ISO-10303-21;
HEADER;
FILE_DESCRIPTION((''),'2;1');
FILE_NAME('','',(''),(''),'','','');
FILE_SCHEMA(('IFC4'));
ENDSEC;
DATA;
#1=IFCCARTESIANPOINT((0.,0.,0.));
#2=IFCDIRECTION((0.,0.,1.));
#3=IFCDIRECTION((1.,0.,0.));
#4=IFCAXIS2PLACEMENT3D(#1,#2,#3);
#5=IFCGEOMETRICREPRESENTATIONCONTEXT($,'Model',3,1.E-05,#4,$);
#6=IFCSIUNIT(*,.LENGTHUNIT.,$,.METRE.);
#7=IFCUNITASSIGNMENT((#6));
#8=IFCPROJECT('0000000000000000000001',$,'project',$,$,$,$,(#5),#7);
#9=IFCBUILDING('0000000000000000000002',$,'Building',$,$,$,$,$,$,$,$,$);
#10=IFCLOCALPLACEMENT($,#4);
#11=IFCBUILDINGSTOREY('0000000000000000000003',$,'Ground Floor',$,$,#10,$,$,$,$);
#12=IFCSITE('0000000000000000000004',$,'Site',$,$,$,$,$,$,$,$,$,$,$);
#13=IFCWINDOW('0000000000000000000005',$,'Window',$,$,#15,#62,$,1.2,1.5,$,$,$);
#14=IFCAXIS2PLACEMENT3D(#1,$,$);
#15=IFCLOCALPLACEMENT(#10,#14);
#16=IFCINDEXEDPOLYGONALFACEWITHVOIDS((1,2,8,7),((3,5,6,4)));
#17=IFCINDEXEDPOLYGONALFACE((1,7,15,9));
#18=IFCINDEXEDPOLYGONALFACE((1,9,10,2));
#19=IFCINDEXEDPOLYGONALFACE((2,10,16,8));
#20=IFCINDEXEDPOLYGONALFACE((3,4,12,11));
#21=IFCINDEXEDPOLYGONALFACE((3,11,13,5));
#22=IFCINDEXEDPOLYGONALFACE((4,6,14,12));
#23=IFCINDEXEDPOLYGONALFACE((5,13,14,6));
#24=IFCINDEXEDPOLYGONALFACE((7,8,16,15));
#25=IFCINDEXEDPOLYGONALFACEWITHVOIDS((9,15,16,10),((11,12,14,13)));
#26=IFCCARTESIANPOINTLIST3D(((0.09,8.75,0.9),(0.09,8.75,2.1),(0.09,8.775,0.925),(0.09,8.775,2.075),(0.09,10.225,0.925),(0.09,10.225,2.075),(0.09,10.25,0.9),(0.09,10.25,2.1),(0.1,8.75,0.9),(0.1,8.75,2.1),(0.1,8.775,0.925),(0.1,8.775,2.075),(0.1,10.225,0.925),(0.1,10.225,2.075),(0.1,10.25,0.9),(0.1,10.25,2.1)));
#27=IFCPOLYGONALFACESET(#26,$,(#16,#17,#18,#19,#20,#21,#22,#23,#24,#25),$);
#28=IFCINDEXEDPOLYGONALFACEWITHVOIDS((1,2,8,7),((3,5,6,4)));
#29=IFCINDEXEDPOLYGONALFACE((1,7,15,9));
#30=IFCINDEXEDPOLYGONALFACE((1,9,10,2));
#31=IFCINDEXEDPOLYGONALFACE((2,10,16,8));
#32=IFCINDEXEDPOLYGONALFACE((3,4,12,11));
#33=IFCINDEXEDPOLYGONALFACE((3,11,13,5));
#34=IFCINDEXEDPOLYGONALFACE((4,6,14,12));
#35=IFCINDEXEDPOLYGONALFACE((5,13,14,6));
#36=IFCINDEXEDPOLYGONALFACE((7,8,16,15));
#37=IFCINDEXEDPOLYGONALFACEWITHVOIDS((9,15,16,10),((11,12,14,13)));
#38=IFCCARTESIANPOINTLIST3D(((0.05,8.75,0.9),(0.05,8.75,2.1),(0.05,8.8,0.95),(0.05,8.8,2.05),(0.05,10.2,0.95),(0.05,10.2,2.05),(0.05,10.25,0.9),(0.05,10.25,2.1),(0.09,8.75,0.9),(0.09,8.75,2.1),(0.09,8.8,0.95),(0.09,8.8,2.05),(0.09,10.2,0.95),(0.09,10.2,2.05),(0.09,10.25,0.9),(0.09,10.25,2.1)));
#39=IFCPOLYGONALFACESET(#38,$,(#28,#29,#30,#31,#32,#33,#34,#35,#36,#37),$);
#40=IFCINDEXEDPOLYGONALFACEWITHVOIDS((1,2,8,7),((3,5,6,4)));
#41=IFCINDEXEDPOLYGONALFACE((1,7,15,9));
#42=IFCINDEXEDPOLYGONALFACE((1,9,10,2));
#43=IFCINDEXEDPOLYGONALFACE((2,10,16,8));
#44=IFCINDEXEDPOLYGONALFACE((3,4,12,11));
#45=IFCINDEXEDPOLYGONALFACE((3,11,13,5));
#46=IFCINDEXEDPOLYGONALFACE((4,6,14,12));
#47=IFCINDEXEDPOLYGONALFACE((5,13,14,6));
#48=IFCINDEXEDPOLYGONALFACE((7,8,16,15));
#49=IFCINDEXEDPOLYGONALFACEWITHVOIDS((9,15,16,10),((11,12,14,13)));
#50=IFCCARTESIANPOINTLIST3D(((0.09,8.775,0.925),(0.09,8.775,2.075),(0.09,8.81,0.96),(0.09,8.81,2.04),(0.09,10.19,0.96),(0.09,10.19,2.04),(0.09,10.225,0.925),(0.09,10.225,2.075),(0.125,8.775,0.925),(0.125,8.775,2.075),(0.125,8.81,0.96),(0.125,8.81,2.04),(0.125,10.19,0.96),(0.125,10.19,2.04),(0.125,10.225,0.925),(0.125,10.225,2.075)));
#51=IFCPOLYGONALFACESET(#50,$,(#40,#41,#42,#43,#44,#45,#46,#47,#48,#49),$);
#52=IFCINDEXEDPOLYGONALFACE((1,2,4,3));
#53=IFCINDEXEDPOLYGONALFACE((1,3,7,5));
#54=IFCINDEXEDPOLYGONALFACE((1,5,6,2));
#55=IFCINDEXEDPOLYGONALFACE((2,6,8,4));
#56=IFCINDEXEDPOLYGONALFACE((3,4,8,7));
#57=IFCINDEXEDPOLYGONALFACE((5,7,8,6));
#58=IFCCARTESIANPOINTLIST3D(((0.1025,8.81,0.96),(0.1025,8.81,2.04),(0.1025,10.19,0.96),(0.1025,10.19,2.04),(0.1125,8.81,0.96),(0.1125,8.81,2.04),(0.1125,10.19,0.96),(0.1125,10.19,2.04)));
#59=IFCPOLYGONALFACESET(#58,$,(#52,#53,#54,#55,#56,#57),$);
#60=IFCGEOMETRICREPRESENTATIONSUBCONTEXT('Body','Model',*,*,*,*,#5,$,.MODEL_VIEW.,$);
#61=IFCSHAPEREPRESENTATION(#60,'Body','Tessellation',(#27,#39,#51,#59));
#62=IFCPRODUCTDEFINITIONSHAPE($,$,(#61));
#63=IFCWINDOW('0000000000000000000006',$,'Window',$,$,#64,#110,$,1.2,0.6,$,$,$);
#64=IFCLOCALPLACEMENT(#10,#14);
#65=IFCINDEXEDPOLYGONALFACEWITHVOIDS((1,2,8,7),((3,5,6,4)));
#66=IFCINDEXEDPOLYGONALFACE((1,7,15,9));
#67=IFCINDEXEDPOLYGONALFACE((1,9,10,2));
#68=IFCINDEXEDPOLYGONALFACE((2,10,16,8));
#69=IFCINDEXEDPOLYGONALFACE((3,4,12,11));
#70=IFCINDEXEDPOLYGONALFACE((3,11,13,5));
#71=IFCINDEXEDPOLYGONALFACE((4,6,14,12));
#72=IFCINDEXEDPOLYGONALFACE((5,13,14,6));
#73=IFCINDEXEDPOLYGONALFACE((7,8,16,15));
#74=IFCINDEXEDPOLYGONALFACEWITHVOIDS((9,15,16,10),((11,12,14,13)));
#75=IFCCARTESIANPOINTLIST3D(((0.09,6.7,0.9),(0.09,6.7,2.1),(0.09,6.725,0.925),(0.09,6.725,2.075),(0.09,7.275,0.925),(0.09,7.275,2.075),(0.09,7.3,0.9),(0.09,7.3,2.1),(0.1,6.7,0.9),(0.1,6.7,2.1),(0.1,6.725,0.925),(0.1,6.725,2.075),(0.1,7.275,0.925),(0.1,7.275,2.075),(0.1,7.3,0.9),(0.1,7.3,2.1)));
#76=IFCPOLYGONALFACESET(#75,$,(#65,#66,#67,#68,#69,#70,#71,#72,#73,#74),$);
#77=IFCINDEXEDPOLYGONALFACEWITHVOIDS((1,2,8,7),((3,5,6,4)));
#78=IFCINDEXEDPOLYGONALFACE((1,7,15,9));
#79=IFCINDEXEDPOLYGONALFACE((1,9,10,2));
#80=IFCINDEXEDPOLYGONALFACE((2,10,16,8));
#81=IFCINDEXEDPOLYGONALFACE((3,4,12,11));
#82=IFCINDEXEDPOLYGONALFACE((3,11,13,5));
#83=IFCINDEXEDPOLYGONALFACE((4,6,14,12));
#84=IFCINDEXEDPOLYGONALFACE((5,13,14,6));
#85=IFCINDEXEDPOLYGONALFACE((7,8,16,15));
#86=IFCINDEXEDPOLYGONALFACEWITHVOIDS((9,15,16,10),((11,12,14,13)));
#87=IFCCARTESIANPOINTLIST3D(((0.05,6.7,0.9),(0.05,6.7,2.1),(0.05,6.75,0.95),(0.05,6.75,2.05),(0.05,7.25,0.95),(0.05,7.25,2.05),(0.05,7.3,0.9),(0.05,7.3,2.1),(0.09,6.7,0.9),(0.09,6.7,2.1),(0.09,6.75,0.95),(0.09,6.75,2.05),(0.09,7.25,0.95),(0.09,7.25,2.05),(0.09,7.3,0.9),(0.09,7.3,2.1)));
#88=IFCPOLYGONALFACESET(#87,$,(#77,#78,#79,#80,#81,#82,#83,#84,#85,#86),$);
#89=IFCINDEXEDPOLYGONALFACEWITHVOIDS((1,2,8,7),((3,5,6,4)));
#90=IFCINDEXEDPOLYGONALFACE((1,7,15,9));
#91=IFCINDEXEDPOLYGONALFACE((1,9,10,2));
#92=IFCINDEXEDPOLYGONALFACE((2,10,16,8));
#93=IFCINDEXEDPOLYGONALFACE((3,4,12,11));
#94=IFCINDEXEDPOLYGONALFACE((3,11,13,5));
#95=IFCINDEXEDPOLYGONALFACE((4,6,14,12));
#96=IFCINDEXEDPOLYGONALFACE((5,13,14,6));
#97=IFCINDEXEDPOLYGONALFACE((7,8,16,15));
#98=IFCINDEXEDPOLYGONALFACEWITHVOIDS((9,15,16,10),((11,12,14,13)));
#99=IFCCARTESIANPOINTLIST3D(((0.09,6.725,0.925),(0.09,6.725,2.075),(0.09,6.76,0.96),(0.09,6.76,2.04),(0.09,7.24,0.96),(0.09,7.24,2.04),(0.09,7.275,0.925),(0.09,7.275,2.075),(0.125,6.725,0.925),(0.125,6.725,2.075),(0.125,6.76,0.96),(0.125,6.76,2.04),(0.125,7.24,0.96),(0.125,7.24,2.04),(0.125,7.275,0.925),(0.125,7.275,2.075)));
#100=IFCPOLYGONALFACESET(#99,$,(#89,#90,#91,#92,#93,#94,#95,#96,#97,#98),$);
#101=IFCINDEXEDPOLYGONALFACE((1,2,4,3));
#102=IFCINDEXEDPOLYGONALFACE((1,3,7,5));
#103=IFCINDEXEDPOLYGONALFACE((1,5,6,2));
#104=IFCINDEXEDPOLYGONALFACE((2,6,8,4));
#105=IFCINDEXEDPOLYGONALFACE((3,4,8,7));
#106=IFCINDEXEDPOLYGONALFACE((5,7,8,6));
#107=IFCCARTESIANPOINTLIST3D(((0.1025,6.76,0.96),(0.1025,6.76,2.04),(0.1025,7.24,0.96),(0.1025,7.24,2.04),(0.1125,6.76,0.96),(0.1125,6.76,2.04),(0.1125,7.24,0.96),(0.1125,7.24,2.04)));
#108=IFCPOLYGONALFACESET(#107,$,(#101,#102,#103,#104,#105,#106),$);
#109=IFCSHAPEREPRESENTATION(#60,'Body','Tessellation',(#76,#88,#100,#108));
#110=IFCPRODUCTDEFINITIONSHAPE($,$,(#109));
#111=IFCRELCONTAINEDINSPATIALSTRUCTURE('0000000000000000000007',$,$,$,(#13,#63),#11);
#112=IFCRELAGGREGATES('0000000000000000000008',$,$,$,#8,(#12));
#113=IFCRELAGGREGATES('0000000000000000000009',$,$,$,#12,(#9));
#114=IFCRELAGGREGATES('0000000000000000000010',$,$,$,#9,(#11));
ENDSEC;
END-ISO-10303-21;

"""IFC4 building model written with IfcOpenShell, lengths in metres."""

from ifc_helpers import new_model, si_unit, frame, origin_with_axes, place, context, subcontext, project, spatial, line, indexed_curve, outline, extrude, element, save


model = new_model("IFC4")

# Units and contexts
model_context = context("Model", 3, precision=1e-05, world=origin_with_axes())
body_context = subcontext(model_context, "Body", "Model", "MODEL_VIEW")
ifc_project = project(units=[si_unit("LENGTHUNIT", "METRE")], contexts=[model_context])

# Site, building, storey
site = spatial("IfcSite", under=ifc_project, Name="Site")
building = spatial("IfcBuilding", under=site, Name="Building")
storey_placement = place(None, origin_with_axes())
storey = spatial("IfcBuildingStorey", under=building, at=storey_placement, Name="Ground Floor")

# Windows
for number, where, z_axis, x_axis, name in (
    (1, (0.0, 10.25, 0.9), (0.0, 0.0, 1.0), (0.0, -1.0, 0.0), "Window"),
):
    element("IfcWindow", number, at=place(storey_placement, frame(where, z_axis=z_axis, x_axis=x_axis)), inside=storey, Name=name, OverallHeight=1.2, OverallWidth=1.5, context=body_context, shape_type="SweptSolid", body=[
        extrude(outline(indexed_curve([(0.0, 0.0), (1.5, 0.0), (1.5, 1.2), (0.0, 1.2)], segments=[line(1, 2, 3, 4, 1)]), holes=[indexed_curve([(0.025, 0.025), (1.475, 0.025), (1.475, 1.175), (0.025, 1.175)], segments=[line(1, 2, 3, 4, 1)])]), frame((0.0, 0.09, 0.0), z_axis=(0.0, -1.0, 0.0), x_axis=(1.0, 0.0, 0.0)), (0.0, 0.0, -1.0), 0.01),
        extrude(outline(indexed_curve([(0.0, 0.0), (1.5, 0.0), (1.5, 1.2), (0.0, 1.2)], segments=[line(1, 2, 3, 4, 1)]), holes=[indexed_curve([(0.05, 0.05), (1.45, 0.05), (1.45, 1.15), (0.05, 1.15)], segments=[line(1, 2, 3, 4, 1)])]), frame((0.0, 0.05, 0.0), z_axis=(0.0, -1.0, 0.0), x_axis=(1.0, 0.0, 0.0)), (0.0, 0.0, -1.0), 0.04),
        extrude(outline(indexed_curve([(0.0, 0.0), (1.45, 0.0), (1.45, 1.15), (0.0, 1.15)], segments=[line(1, 2, 3, 4, 1)]), holes=[indexed_curve([(0.035, 0.035), (1.415, 0.035), (1.415, 1.115), (0.035, 1.115)], segments=[line(1, 2, 3, 4, 1)])]), frame((0.025, 0.09, 0.025), z_axis=(0.0, -1.0, 0.0), x_axis=(1.0, 0.0, 0.0)), (0.0, 0.0, -1.0), 0.035),
        extrude(outline(indexed_curve([(0.035, 0.035), (1.415, 0.035), (1.415, 1.115), (0.035, 1.115)], segments=[line(1, 2, 3, 4, 1)])), frame((0.025, 0.1025, 0.025), z_axis=(0.0, -1.0, 0.0), x_axis=(1.0, 0.0, 0.0)), (0.0, 0.0, -1.0), 0.01),
    ])
window_1_placement = place(storey_placement, frame((0.0, 7.3, 0.9), z_axis=(0.0, 0.0, 1.0), x_axis=(0.0, -1.0, 0.0)))
element("IfcWindow", 2, at=window_1_placement, inside=storey, Name="Window", OverallHeight=1.2, OverallWidth=0.6, context=body_context, shape_type="SweptSolid", body=[
    extrude(outline(indexed_curve([(0.0, 0.0), (0.6, 0.0), (0.6, 1.2), (0.0, 1.2)], segments=[line(1, 2, 3, 4, 1)]), holes=[indexed_curve([(0.025, 0.025), (0.575, 0.025), (0.575, 1.175), (0.025, 1.175)], segments=[line(1, 2, 3, 4, 1)])]), frame((0.0, 0.09, 0.0), z_axis=(0.0, -1.0, 0.0), x_axis=(1.0, 0.0, 0.0)), (0.0, 0.0, -1.0), 0.01),
    extrude(outline(indexed_curve([(0.0, 0.0), (0.6, 0.0), (0.6, 1.2), (0.0, 1.2)], segments=[line(1, 2, 3, 4, 1)]), holes=[indexed_curve([(0.05, 0.05), (0.55, 0.05), (0.55, 1.15), (0.05, 1.15)], segments=[line(1, 2, 3, 4, 1)])]), frame((0.0, 0.05, 0.0), z_axis=(0.0, -1.0, 0.0), x_axis=(1.0, 0.0, 0.0)), (0.0, 0.0, -1.0), 0.04),
    extrude(outline(indexed_curve([(0.0, 0.0), (0.55, 0.0), (0.55, 1.15), (0.0, 1.15)], segments=[line(1, 2, 3, 4, 1)]), holes=[indexed_curve([(0.035, 0.035), (0.515, 0.035), (0.515, 1.115), (0.035, 1.115)], segments=[line(1, 2, 3, 4, 1)])]), frame((0.025, 0.09, 0.025), z_axis=(0.0, -1.0, 0.0), x_axis=(1.0, 0.0, 0.0)), (0.0, 0.0, -1.0), 0.035),
    extrude(outline(indexed_curve([(0.035, 0.035), (0.515, 0.035), (0.515, 1.115), (0.035, 1.115)], segments=[line(1, 2, 3, 4, 1)])), frame((0.025, 0.1025, 0.025), z_axis=(0.0, -1.0, 0.0), x_axis=(1.0, 0.0, 0.0)), (0.0, 0.0, -1.0), 0.01),
])

save(model, "model.ifc")
